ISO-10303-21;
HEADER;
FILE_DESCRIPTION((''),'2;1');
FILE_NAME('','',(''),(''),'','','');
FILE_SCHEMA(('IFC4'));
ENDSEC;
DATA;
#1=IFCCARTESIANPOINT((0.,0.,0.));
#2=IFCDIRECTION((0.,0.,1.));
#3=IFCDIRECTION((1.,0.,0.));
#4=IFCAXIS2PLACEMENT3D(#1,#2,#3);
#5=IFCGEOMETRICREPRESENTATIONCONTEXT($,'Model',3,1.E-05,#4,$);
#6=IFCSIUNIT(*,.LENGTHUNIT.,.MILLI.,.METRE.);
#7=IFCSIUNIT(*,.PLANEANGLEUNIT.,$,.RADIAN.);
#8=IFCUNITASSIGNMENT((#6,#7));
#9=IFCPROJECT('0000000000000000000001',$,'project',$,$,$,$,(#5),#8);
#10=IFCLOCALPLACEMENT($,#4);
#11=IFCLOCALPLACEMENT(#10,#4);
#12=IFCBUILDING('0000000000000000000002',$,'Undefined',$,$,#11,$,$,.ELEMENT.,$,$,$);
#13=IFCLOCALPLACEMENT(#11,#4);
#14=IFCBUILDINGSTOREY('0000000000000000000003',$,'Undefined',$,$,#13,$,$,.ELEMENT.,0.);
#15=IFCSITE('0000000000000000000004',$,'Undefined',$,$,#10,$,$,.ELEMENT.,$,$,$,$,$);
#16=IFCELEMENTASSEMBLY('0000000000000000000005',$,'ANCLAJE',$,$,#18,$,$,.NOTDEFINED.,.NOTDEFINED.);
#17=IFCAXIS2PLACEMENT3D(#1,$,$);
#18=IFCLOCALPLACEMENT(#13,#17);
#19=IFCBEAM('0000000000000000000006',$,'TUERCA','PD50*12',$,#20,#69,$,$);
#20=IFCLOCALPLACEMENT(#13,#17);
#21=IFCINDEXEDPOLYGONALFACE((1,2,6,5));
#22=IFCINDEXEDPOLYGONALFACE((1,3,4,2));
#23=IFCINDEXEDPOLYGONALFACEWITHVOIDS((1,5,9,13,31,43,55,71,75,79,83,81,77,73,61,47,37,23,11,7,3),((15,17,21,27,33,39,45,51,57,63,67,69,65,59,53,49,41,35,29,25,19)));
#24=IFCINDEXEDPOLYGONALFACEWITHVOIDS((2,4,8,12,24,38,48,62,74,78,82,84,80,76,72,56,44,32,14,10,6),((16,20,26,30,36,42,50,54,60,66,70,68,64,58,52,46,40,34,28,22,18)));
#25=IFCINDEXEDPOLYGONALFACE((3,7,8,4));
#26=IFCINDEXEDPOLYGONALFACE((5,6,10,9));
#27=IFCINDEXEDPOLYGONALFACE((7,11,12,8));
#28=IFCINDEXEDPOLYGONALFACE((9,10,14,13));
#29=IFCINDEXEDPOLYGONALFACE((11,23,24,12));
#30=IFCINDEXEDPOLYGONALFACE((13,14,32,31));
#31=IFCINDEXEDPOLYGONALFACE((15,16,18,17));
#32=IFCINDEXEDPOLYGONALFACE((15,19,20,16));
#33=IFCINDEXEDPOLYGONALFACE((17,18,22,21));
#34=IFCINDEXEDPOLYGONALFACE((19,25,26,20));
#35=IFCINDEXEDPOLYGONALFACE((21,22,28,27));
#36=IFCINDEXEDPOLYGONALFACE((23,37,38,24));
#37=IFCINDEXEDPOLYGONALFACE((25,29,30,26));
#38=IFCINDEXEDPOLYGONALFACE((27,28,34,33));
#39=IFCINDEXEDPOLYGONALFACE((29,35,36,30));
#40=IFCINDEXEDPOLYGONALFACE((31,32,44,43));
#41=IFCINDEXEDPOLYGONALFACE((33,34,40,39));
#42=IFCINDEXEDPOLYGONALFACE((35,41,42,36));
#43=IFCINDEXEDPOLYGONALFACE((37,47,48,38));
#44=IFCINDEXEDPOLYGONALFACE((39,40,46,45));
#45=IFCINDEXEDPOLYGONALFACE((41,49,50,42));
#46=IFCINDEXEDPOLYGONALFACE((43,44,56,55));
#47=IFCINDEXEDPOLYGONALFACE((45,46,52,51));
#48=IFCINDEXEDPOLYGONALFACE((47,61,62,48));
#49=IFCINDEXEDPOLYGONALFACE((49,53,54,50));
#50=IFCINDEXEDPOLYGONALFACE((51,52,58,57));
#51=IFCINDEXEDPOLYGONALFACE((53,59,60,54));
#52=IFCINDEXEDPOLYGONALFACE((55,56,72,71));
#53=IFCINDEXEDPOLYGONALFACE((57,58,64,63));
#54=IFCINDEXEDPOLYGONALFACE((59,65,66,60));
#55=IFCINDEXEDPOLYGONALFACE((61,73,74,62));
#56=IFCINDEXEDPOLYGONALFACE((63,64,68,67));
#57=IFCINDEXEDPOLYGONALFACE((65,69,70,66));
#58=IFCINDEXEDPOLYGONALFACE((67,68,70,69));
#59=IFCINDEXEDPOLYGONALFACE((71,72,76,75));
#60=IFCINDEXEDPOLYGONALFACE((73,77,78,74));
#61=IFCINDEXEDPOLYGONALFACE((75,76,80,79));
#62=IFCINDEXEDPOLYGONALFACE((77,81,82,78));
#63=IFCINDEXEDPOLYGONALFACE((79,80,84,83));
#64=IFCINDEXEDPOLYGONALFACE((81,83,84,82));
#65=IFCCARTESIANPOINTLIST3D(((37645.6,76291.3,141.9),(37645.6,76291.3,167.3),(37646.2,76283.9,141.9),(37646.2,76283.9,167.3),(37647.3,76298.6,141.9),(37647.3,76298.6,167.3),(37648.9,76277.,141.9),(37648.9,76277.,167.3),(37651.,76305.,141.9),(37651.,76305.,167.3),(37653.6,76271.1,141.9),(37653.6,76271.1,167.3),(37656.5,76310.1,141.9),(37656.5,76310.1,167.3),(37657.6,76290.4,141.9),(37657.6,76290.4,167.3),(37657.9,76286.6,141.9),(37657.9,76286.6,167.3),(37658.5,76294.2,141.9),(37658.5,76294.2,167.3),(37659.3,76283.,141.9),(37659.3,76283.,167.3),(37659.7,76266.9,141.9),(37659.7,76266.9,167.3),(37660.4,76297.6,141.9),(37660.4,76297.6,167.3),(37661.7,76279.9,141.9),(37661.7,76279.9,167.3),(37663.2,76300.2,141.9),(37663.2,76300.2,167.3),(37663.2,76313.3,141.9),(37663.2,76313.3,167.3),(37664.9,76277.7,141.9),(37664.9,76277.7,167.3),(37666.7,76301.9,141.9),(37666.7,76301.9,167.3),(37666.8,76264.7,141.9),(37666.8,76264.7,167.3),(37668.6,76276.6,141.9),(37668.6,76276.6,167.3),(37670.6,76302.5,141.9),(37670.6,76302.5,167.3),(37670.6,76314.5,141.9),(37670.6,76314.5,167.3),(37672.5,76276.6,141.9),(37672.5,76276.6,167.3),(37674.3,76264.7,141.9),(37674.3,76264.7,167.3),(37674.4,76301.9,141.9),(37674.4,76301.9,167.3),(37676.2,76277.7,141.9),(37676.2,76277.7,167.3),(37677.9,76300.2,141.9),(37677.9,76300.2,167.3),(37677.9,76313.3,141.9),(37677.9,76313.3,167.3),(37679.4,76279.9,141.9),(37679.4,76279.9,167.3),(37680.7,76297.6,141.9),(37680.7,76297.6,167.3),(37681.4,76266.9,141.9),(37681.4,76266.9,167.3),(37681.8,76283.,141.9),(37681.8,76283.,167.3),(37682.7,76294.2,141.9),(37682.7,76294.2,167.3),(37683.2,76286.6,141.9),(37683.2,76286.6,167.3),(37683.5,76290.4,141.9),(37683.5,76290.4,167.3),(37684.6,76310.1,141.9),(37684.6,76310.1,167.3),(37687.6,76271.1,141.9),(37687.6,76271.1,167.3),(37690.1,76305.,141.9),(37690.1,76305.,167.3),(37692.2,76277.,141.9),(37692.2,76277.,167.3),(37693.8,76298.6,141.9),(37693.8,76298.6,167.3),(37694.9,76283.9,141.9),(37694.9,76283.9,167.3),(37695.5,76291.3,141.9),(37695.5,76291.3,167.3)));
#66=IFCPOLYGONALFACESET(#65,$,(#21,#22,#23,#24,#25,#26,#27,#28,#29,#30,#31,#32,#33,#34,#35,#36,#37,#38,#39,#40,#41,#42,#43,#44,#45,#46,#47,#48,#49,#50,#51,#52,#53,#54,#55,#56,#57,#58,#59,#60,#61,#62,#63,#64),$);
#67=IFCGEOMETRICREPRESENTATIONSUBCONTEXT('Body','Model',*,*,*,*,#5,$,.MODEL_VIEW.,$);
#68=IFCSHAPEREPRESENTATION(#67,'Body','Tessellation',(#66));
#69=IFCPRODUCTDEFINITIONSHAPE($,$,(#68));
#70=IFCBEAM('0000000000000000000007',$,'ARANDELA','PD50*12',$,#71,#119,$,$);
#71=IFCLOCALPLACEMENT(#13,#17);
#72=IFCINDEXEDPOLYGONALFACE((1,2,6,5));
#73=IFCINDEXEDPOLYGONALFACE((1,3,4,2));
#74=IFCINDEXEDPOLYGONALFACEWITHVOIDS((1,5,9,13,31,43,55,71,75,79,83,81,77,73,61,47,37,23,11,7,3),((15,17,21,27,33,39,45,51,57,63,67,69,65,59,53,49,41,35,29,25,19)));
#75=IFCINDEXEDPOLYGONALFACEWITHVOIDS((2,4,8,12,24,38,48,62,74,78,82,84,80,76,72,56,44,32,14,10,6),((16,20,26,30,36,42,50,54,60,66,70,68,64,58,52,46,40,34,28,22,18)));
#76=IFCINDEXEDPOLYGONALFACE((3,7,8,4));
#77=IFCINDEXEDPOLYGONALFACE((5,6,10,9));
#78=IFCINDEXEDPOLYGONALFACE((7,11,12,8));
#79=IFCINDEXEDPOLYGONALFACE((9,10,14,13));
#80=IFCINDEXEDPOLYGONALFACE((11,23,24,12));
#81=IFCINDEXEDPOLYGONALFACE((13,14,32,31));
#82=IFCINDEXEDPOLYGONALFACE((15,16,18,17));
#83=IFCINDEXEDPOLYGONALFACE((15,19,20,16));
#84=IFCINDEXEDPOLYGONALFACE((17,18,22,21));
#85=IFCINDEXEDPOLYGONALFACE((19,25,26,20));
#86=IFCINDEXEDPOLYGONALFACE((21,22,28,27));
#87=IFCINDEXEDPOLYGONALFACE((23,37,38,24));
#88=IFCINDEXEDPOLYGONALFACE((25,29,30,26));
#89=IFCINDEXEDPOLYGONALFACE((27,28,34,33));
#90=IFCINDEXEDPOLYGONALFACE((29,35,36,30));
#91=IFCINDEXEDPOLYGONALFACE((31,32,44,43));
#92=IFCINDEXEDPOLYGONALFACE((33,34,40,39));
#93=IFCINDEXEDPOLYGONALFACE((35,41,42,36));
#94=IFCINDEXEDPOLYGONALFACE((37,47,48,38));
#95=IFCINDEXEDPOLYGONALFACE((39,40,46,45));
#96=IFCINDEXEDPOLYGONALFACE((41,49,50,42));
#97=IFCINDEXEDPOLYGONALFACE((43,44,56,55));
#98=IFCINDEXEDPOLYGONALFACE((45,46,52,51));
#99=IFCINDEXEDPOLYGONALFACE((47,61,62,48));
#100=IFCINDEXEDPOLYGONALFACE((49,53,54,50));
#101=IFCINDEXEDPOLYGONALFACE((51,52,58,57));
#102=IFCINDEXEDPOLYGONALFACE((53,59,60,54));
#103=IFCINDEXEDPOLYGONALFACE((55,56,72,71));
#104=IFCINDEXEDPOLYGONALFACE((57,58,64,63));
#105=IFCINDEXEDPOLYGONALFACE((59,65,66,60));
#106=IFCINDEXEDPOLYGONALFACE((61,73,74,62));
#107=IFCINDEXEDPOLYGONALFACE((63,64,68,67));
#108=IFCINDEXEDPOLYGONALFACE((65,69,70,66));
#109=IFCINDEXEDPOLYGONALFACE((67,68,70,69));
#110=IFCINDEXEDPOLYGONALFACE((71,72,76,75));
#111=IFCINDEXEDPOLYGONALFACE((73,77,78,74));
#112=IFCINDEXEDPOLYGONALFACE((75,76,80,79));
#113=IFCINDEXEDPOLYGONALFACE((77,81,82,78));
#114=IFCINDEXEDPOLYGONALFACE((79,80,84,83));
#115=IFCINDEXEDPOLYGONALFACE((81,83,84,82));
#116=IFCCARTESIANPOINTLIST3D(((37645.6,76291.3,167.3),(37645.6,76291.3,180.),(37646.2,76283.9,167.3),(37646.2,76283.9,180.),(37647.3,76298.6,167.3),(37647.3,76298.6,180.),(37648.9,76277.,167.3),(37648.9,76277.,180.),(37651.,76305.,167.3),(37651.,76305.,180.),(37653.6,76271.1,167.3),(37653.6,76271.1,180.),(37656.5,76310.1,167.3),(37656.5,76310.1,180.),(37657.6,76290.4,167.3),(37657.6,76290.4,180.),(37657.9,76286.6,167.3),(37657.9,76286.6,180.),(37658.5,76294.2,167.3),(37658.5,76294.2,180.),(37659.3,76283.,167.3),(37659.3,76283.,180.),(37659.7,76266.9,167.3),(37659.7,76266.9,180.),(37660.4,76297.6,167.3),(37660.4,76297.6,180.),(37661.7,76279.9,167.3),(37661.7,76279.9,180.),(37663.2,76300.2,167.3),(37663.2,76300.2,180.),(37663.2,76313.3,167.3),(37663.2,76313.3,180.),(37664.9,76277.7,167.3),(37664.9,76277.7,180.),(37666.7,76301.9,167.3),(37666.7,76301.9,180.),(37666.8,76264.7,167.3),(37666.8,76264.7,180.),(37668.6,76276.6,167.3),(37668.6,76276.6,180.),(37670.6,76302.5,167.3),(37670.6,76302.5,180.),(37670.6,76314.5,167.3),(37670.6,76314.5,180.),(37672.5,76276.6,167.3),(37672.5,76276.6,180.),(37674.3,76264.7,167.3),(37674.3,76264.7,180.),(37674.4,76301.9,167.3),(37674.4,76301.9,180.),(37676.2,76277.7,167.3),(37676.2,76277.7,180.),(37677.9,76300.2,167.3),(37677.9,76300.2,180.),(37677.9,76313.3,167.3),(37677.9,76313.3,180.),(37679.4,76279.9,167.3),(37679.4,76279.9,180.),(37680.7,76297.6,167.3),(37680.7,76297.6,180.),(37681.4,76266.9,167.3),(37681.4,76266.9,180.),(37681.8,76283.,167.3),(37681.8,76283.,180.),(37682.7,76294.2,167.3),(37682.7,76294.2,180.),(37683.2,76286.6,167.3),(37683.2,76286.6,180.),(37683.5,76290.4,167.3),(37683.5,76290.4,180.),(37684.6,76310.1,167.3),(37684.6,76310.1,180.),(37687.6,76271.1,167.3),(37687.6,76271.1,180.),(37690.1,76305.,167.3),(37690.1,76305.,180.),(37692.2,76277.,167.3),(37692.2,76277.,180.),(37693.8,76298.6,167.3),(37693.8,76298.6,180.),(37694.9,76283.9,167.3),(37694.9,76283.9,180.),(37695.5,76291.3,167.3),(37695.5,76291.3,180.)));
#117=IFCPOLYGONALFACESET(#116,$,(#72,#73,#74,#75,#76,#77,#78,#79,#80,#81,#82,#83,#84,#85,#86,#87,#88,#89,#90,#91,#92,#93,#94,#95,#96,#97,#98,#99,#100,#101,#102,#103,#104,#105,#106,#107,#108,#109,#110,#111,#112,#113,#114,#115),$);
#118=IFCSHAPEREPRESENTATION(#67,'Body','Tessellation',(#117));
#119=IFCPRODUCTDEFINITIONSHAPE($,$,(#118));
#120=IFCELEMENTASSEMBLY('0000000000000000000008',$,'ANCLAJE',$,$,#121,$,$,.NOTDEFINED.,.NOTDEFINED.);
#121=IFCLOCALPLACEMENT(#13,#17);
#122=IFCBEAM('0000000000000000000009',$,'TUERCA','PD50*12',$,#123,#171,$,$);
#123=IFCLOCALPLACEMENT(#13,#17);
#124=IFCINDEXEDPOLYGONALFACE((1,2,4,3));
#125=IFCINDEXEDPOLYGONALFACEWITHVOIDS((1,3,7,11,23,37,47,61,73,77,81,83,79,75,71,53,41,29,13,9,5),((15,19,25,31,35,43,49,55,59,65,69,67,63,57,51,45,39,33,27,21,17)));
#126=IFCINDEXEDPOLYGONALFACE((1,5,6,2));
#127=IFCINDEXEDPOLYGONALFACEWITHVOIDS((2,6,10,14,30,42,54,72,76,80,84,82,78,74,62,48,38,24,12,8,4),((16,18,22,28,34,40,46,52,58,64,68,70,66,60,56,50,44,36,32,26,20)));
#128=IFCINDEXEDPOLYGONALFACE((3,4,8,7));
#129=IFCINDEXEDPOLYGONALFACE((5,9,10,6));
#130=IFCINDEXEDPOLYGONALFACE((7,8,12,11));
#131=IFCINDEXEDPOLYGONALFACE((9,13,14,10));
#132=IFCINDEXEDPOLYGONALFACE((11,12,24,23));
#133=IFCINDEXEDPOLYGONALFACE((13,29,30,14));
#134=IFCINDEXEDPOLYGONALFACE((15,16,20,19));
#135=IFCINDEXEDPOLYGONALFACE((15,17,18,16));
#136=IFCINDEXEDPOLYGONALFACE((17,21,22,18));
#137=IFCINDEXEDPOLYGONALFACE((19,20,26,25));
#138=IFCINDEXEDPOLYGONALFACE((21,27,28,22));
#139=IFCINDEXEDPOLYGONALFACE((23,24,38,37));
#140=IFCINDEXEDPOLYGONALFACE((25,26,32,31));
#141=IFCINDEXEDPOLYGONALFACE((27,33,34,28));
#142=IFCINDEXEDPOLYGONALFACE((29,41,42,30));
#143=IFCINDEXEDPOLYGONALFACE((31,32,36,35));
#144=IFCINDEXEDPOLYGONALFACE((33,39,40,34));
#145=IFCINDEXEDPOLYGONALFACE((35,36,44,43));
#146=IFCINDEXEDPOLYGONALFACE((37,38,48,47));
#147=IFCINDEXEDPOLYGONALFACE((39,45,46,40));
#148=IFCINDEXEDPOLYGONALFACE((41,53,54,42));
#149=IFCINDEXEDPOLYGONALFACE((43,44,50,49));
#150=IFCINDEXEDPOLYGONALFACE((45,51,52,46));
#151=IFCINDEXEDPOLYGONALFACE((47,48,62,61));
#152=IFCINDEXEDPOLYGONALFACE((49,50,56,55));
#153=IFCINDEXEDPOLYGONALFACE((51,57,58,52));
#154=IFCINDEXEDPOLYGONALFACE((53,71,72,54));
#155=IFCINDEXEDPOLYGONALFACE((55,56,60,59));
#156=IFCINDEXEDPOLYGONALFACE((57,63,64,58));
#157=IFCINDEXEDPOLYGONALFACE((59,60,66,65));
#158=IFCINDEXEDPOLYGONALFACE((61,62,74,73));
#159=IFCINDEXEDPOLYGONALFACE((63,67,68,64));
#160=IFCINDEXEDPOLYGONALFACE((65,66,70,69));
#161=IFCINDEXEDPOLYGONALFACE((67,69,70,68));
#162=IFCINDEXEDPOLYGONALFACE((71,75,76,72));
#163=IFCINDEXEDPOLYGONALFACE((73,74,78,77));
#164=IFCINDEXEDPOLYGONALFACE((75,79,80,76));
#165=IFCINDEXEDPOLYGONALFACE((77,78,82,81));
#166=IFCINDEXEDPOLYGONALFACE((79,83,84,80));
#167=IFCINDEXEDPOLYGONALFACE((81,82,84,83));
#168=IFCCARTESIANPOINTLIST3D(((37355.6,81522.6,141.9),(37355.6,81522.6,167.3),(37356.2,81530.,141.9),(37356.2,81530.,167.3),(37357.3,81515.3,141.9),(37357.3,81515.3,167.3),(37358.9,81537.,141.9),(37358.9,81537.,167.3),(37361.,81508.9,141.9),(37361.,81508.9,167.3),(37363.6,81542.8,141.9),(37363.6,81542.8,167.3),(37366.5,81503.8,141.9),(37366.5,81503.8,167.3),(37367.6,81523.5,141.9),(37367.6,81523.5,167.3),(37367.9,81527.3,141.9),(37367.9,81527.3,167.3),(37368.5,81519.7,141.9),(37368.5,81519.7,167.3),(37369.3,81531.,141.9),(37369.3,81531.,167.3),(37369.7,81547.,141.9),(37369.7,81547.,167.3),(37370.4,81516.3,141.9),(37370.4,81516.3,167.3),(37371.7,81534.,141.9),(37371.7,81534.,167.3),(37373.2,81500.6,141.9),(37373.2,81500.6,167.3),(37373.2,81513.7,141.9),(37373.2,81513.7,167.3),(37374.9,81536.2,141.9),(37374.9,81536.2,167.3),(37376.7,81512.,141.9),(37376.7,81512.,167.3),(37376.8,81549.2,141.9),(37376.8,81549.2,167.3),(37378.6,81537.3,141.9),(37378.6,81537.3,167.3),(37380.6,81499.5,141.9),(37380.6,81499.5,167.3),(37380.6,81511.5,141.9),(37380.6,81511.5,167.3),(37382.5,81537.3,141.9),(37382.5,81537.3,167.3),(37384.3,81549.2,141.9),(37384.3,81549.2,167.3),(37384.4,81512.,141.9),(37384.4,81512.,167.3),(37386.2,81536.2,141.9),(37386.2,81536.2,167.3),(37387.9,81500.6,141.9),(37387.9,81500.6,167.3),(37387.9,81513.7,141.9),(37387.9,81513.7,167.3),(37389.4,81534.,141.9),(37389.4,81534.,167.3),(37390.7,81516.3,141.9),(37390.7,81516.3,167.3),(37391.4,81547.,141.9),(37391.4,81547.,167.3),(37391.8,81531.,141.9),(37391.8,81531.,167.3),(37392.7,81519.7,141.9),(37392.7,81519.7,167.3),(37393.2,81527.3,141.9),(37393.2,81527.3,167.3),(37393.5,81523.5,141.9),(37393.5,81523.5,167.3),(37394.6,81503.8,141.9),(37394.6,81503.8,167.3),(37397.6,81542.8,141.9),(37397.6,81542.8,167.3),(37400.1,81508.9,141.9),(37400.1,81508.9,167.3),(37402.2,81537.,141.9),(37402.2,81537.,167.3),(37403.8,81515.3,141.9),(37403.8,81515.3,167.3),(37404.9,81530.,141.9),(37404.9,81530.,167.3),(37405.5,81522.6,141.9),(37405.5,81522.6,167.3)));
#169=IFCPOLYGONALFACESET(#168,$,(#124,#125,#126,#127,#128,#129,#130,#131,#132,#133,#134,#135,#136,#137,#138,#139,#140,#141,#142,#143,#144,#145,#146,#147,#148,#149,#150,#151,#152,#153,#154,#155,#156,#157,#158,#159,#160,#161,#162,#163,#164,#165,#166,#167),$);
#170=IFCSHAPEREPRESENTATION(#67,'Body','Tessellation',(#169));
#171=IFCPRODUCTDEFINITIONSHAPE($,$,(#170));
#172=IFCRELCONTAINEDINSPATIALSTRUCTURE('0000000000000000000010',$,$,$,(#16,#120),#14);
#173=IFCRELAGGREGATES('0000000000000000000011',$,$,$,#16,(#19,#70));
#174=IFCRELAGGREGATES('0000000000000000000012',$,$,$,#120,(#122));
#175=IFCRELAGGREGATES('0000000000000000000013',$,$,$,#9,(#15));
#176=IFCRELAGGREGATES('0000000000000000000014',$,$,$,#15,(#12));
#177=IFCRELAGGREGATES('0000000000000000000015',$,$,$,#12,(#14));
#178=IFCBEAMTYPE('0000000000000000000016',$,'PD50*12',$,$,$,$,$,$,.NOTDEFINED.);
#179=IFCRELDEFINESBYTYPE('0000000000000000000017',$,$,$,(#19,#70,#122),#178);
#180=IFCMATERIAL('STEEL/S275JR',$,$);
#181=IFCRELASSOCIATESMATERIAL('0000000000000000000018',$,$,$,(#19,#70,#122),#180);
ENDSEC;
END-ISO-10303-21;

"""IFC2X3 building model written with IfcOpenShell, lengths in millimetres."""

from ifc_helpers import new_model, si_unit, frame, origin_with_axes, origin_2d_with_axis, place, context, subcontext, project, spatial, hollow_circle, extrude, material, type_object, element, aggregate, save


model = new_model("IFC2X3")

# Units and contexts
model_context = context("Model", 3, precision=1e-05, world=origin_with_axes())
body_context = subcontext(model_context, "Body", "Model", "MODEL_VIEW")
ifc_project = project(units=[si_unit("LENGTHUNIT", "METRE", prefix="MILLI"), si_unit("PLANEANGLEUNIT", "RADIAN")], contexts=[model_context])

# Site, building, storey
site_placement = place(None, origin_with_axes())
site = spatial("IfcSite", under=ifc_project, at=site_placement, Name="Undefined", CompositionType="ELEMENT")
building_placement = place(site_placement, origin_with_axes())
building = spatial("IfcBuilding", under=site, at=building_placement, Name="Undefined", CompositionType="ELEMENT")
storey_placement = place(building_placement, origin_with_axes())
storey = spatial("IfcBuildingStorey", under=building, at=storey_placement, Name="Undefined", CompositionType="ELEMENT", Elevation=0.0)

# Element assemblies, beams
assembly_1_placement = place(storey_placement, origin_with_axes())
assembly_1 = element("IfcElementAssembly", 1, at=assembly_1_placement, inside=storey, Name="ANCLAJE", AssemblyPlace="NOTDEFINED", PredefinedType="NOTDEFINED")
ifc_material_1 = material(Name="STEEL/S275JR")
beam_type = type_object("IfcBeamType", Name="PD50*12", PredefinedType="NOTDEFINED")
beam_1_placement = place(assembly_1_placement, frame((37670.6, 76289.5, 167.3), z_axis=(-1.0, 0.0, 0.0), x_axis=(0.0, 0.0, -1.0)))
beam_1 = element("IfcBeam", 2, at=beam_1_placement, type_object=beam_type, material=ifc_material_1, Name="TUERCA", Description="PD50*12", context=body_context, shape_type="SweptSolid", body=[
    extrude(hollow_circle(Radius=25.0, WallThickness=12.0, at=origin_2d_with_axis()), frame((25.4, 0.0, 0.0), z_axis=(-1.0, 0.0, 0.0), x_axis=(0.0, -1.0, 0.0)), (0.0, 0.0, 1.0), 25.4),
])
beam_2_placement = place(assembly_1_placement, frame((37670.6, 76289.5, 180.0), z_axis=(-1.0, 0.0, 0.0), x_axis=(0.0, 0.0, -1.0)))
beam_2 = element("IfcBeam", 3, at=beam_2_placement, type_object=beam_type, material=ifc_material_1, Name="ARANDELA", Description="PD50*12", context=body_context, shape_type="SweptSolid", body=[
    extrude(hollow_circle(Radius=25.0, WallThickness=12.0, at=origin_2d_with_axis()), frame((12.7, 0.0, 0.0), z_axis=(-1.0, 0.0, 0.0), x_axis=(0.0, -1.0, 0.0)), (0.0, 0.0, 1.0), 12.7),
])
assembly_2_placement = place(storey_placement, origin_with_axes())
assembly_2 = element("IfcElementAssembly", 4, at=assembly_2_placement, inside=storey, Name="ANCLAJE", AssemblyPlace="NOTDEFINED", PredefinedType="NOTDEFINED")
beam_3_placement = place(assembly_2_placement, frame((37380.6, 81524.5, 167.3), z_axis=(1.0, 0.0, 0.0), x_axis=(0.0, 0.0, -1.0)))
beam_3 = element("IfcBeam", 5, at=beam_3_placement, type_object=beam_type, material=ifc_material_1, Name="TUERCA", Description="PD50*12", context=body_context, shape_type="SweptSolid", body=[
    extrude(hollow_circle(Radius=25.0, WallThickness=12.0, at=origin_2d_with_axis()), frame((25.4, 0.0, 0.0), z_axis=(-1.0, 0.0, 0.0), x_axis=(0.0, -1.0, 0.0)), (0.0, 0.0, 1.0), 25.4),
])

aggregate(assembly_1, [beam_1, beam_2])
aggregate(assembly_2, [beam_3])

save(model, "model.ifc")
